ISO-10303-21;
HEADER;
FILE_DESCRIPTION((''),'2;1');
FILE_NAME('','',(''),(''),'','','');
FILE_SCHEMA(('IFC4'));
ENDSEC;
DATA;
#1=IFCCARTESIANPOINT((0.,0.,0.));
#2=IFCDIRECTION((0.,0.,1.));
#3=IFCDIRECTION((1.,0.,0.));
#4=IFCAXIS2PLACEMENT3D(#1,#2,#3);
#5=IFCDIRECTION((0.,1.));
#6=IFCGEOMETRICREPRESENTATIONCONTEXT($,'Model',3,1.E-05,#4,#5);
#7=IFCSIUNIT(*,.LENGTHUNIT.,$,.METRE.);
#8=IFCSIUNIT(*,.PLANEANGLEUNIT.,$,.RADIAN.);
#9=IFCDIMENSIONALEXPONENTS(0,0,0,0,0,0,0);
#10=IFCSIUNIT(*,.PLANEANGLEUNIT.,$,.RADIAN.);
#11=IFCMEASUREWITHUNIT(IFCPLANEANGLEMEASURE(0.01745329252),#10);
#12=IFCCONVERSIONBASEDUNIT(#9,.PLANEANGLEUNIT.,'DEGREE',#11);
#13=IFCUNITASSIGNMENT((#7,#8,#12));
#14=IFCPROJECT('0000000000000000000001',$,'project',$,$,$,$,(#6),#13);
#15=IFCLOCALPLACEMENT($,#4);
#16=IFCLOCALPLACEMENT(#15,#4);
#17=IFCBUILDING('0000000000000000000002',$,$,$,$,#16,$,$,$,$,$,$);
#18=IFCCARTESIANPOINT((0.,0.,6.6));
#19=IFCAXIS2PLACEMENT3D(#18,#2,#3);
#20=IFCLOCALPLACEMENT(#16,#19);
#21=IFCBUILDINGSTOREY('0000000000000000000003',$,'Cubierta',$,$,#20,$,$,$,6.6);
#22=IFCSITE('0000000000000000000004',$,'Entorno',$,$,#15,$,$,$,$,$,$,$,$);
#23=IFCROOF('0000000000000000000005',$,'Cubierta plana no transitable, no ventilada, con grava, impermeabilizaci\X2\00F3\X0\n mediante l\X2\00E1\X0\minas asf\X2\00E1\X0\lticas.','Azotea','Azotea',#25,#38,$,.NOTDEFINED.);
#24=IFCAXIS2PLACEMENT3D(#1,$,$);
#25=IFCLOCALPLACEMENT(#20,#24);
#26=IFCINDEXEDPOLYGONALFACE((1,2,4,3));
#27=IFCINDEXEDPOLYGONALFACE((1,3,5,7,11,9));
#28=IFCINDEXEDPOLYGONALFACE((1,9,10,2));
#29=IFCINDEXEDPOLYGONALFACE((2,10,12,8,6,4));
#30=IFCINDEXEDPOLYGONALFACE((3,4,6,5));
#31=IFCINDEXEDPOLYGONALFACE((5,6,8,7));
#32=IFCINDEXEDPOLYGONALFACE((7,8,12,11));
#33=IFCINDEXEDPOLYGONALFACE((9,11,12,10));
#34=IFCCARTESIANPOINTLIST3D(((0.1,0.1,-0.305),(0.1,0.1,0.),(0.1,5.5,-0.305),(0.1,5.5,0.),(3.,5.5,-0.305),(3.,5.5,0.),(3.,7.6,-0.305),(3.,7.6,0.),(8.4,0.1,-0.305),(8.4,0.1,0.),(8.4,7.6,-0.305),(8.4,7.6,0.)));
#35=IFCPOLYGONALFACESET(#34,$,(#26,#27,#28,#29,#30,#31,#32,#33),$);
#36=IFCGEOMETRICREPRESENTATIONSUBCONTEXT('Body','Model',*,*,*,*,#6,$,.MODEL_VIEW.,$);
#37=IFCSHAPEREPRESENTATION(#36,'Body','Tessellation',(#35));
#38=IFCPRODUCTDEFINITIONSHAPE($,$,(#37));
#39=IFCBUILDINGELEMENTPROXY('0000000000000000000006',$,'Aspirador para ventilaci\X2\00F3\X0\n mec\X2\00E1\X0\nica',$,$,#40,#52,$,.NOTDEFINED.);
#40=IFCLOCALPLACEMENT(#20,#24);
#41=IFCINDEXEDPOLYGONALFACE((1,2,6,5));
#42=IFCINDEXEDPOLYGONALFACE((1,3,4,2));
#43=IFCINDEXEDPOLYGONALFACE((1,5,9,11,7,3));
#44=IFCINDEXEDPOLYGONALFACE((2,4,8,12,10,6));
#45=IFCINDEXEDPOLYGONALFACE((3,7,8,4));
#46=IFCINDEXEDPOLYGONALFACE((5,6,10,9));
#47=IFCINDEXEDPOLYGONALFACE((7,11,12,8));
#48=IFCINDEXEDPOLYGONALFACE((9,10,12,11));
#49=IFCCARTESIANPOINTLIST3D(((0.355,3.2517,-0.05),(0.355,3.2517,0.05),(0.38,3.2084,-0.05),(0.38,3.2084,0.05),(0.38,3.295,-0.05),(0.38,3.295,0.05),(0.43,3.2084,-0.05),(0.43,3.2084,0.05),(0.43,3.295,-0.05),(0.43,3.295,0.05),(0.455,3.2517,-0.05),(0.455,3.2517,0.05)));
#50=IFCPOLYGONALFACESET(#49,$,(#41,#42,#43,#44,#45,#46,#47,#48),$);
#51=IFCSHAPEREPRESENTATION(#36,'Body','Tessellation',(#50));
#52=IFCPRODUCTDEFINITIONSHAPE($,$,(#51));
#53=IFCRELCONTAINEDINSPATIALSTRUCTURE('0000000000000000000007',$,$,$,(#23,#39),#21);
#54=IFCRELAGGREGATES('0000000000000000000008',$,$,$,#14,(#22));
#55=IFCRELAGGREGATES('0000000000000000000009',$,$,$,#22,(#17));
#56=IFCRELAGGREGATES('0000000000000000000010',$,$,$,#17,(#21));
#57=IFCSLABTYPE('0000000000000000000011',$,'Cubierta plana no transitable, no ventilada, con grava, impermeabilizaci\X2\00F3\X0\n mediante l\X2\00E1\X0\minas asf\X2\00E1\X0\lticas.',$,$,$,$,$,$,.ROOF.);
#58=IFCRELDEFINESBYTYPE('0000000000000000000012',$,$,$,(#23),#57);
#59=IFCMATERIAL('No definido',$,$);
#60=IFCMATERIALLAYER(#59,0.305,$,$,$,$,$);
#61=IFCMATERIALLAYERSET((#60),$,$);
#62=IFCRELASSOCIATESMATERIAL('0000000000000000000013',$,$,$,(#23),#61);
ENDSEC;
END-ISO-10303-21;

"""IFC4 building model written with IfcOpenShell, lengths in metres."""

from ifc_helpers import new_model, entity, si_unit, converted_unit, direction, frame, origin_with_axes, place, context, subcontext, project, spatial, polyline, outline, extrude, source, transform, mapped, material, layer, layer_set, layer_usage, type_object, element, save


model = new_model("IFC4")

# Units and contexts
model_context = context("Model", 3, precision=1e-05, world=origin_with_axes(), true_north=direction((0.0, 1.0)))
body_context = subcontext(model_context, "Body", "Model", "MODEL_VIEW")
ifc_project = project(units=[si_unit("LENGTHUNIT", "METRE"), si_unit("PLANEANGLEUNIT", "RADIAN"), converted_unit("PLANEANGLEUNIT", "DEGREE", entity("IfcPlaneAngleMeasure", 0.01745329252), si_unit("PLANEANGLEUNIT", "RADIAN"), dimensions=[0, 0, 0, 0, 0, 0, 0])], contexts=[model_context])

# Site, building, storey
site_placement = place(None, origin_with_axes())
site = spatial("IfcSite", under=ifc_project, at=site_placement, Name="Entorno")
building_placement = place(site_placement, origin_with_axes())
building = spatial("IfcBuilding", under=site, at=building_placement)
storey_placement = place(building_placement, frame((0.0, 0.0, 6.6), z_axis=(0.0, 0.0, 1.0), x_axis=(1.0, 0.0, 0.0)))
storey = spatial("IfcBuildingStorey", under=building, at=storey_placement, Name="Cubierta", Elevation=6.6)

# Roof
ifc_material = material(Name="No definido")
ifc_layer = layer(ifc_material, 0.305)
ifc_layer_set = layer_set([ifc_layer])
ifc_layer_usage = layer_usage(ifc_layer_set, "AXIS3", "POSITIVE", 0.0)
slab_type = type_object("IfcSlabType", Name="Cubierta plana no transitable, no ventilada, con grava, impermeabilización mediante láminas asfálticas.", PredefinedType="ROOF")
roof_placement = place(storey_placement, frame((3.0, 7.6, -0.305), z_axis=(0.0, 0.0, 1.0), x_axis=(1.0, 0.0, 0.0)))
element("IfcRoof", 1, at=roof_placement, inside=storey, type_object=slab_type, material=ifc_layer_usage, Name="Cubierta plana no transitable, no ventilada, con grava, impermeabilización mediante láminas asfálticas.", Description="Azotea", ObjectType="Azotea", PredefinedType="NOTDEFINED", context=body_context, shape_type="SweptSolid", body=[
    extrude(outline(polyline([(0.0, 0.0), (0.0, -2.1), (-2.9, -2.1), (-2.9, -7.5), (5.4, -7.5), (5.4, 0.0), (0.0, 0.0)])), origin_with_axes(), (0.0, 0.0, 1.0), 0.305),
])

# Building element proxy
shared_shape = source(origin_with_axes(), body_context, "Body", "SolidModel", [
    extrude(outline(polyline([(0.05, 0.0), (0.025, 0.0433), (-0.025, 0.0433), (-0.05, 0.0), (-0.025, -0.0433), (0.025, -0.0433), (0.05, 0.0)])), frame((0.0, 0.0, -0.05), z_axis=(0.0, 0.0, 1.0), x_axis=(1.0, 0.0, 0.0)), (0.0, 0.0, 1.0), 0.1),
])
proxy_1_placement = place(storey_placement, frame((0.0, 0.0, -6.6), z_axis=(0.0, 0.0, 1.0), x_axis=(1.0, 0.0, 0.0)))
element("IfcBuildingElementProxy", 2, at=proxy_1_placement, inside=storey, Name="Aspirador para ventilación mecánica", PredefinedType="NOTDEFINED", context=body_context, shape_type="Brep", body=[
    mapped(shared_shape, transform((0.405, 3.2517, 6.6), x_axis=(-1.0, 0.0, 0.0), y_axis=(0.0, -1.0, 0.0), z_axis=(0.0, 0.0, 1.0))),
])

save(model, "model.ifc")
